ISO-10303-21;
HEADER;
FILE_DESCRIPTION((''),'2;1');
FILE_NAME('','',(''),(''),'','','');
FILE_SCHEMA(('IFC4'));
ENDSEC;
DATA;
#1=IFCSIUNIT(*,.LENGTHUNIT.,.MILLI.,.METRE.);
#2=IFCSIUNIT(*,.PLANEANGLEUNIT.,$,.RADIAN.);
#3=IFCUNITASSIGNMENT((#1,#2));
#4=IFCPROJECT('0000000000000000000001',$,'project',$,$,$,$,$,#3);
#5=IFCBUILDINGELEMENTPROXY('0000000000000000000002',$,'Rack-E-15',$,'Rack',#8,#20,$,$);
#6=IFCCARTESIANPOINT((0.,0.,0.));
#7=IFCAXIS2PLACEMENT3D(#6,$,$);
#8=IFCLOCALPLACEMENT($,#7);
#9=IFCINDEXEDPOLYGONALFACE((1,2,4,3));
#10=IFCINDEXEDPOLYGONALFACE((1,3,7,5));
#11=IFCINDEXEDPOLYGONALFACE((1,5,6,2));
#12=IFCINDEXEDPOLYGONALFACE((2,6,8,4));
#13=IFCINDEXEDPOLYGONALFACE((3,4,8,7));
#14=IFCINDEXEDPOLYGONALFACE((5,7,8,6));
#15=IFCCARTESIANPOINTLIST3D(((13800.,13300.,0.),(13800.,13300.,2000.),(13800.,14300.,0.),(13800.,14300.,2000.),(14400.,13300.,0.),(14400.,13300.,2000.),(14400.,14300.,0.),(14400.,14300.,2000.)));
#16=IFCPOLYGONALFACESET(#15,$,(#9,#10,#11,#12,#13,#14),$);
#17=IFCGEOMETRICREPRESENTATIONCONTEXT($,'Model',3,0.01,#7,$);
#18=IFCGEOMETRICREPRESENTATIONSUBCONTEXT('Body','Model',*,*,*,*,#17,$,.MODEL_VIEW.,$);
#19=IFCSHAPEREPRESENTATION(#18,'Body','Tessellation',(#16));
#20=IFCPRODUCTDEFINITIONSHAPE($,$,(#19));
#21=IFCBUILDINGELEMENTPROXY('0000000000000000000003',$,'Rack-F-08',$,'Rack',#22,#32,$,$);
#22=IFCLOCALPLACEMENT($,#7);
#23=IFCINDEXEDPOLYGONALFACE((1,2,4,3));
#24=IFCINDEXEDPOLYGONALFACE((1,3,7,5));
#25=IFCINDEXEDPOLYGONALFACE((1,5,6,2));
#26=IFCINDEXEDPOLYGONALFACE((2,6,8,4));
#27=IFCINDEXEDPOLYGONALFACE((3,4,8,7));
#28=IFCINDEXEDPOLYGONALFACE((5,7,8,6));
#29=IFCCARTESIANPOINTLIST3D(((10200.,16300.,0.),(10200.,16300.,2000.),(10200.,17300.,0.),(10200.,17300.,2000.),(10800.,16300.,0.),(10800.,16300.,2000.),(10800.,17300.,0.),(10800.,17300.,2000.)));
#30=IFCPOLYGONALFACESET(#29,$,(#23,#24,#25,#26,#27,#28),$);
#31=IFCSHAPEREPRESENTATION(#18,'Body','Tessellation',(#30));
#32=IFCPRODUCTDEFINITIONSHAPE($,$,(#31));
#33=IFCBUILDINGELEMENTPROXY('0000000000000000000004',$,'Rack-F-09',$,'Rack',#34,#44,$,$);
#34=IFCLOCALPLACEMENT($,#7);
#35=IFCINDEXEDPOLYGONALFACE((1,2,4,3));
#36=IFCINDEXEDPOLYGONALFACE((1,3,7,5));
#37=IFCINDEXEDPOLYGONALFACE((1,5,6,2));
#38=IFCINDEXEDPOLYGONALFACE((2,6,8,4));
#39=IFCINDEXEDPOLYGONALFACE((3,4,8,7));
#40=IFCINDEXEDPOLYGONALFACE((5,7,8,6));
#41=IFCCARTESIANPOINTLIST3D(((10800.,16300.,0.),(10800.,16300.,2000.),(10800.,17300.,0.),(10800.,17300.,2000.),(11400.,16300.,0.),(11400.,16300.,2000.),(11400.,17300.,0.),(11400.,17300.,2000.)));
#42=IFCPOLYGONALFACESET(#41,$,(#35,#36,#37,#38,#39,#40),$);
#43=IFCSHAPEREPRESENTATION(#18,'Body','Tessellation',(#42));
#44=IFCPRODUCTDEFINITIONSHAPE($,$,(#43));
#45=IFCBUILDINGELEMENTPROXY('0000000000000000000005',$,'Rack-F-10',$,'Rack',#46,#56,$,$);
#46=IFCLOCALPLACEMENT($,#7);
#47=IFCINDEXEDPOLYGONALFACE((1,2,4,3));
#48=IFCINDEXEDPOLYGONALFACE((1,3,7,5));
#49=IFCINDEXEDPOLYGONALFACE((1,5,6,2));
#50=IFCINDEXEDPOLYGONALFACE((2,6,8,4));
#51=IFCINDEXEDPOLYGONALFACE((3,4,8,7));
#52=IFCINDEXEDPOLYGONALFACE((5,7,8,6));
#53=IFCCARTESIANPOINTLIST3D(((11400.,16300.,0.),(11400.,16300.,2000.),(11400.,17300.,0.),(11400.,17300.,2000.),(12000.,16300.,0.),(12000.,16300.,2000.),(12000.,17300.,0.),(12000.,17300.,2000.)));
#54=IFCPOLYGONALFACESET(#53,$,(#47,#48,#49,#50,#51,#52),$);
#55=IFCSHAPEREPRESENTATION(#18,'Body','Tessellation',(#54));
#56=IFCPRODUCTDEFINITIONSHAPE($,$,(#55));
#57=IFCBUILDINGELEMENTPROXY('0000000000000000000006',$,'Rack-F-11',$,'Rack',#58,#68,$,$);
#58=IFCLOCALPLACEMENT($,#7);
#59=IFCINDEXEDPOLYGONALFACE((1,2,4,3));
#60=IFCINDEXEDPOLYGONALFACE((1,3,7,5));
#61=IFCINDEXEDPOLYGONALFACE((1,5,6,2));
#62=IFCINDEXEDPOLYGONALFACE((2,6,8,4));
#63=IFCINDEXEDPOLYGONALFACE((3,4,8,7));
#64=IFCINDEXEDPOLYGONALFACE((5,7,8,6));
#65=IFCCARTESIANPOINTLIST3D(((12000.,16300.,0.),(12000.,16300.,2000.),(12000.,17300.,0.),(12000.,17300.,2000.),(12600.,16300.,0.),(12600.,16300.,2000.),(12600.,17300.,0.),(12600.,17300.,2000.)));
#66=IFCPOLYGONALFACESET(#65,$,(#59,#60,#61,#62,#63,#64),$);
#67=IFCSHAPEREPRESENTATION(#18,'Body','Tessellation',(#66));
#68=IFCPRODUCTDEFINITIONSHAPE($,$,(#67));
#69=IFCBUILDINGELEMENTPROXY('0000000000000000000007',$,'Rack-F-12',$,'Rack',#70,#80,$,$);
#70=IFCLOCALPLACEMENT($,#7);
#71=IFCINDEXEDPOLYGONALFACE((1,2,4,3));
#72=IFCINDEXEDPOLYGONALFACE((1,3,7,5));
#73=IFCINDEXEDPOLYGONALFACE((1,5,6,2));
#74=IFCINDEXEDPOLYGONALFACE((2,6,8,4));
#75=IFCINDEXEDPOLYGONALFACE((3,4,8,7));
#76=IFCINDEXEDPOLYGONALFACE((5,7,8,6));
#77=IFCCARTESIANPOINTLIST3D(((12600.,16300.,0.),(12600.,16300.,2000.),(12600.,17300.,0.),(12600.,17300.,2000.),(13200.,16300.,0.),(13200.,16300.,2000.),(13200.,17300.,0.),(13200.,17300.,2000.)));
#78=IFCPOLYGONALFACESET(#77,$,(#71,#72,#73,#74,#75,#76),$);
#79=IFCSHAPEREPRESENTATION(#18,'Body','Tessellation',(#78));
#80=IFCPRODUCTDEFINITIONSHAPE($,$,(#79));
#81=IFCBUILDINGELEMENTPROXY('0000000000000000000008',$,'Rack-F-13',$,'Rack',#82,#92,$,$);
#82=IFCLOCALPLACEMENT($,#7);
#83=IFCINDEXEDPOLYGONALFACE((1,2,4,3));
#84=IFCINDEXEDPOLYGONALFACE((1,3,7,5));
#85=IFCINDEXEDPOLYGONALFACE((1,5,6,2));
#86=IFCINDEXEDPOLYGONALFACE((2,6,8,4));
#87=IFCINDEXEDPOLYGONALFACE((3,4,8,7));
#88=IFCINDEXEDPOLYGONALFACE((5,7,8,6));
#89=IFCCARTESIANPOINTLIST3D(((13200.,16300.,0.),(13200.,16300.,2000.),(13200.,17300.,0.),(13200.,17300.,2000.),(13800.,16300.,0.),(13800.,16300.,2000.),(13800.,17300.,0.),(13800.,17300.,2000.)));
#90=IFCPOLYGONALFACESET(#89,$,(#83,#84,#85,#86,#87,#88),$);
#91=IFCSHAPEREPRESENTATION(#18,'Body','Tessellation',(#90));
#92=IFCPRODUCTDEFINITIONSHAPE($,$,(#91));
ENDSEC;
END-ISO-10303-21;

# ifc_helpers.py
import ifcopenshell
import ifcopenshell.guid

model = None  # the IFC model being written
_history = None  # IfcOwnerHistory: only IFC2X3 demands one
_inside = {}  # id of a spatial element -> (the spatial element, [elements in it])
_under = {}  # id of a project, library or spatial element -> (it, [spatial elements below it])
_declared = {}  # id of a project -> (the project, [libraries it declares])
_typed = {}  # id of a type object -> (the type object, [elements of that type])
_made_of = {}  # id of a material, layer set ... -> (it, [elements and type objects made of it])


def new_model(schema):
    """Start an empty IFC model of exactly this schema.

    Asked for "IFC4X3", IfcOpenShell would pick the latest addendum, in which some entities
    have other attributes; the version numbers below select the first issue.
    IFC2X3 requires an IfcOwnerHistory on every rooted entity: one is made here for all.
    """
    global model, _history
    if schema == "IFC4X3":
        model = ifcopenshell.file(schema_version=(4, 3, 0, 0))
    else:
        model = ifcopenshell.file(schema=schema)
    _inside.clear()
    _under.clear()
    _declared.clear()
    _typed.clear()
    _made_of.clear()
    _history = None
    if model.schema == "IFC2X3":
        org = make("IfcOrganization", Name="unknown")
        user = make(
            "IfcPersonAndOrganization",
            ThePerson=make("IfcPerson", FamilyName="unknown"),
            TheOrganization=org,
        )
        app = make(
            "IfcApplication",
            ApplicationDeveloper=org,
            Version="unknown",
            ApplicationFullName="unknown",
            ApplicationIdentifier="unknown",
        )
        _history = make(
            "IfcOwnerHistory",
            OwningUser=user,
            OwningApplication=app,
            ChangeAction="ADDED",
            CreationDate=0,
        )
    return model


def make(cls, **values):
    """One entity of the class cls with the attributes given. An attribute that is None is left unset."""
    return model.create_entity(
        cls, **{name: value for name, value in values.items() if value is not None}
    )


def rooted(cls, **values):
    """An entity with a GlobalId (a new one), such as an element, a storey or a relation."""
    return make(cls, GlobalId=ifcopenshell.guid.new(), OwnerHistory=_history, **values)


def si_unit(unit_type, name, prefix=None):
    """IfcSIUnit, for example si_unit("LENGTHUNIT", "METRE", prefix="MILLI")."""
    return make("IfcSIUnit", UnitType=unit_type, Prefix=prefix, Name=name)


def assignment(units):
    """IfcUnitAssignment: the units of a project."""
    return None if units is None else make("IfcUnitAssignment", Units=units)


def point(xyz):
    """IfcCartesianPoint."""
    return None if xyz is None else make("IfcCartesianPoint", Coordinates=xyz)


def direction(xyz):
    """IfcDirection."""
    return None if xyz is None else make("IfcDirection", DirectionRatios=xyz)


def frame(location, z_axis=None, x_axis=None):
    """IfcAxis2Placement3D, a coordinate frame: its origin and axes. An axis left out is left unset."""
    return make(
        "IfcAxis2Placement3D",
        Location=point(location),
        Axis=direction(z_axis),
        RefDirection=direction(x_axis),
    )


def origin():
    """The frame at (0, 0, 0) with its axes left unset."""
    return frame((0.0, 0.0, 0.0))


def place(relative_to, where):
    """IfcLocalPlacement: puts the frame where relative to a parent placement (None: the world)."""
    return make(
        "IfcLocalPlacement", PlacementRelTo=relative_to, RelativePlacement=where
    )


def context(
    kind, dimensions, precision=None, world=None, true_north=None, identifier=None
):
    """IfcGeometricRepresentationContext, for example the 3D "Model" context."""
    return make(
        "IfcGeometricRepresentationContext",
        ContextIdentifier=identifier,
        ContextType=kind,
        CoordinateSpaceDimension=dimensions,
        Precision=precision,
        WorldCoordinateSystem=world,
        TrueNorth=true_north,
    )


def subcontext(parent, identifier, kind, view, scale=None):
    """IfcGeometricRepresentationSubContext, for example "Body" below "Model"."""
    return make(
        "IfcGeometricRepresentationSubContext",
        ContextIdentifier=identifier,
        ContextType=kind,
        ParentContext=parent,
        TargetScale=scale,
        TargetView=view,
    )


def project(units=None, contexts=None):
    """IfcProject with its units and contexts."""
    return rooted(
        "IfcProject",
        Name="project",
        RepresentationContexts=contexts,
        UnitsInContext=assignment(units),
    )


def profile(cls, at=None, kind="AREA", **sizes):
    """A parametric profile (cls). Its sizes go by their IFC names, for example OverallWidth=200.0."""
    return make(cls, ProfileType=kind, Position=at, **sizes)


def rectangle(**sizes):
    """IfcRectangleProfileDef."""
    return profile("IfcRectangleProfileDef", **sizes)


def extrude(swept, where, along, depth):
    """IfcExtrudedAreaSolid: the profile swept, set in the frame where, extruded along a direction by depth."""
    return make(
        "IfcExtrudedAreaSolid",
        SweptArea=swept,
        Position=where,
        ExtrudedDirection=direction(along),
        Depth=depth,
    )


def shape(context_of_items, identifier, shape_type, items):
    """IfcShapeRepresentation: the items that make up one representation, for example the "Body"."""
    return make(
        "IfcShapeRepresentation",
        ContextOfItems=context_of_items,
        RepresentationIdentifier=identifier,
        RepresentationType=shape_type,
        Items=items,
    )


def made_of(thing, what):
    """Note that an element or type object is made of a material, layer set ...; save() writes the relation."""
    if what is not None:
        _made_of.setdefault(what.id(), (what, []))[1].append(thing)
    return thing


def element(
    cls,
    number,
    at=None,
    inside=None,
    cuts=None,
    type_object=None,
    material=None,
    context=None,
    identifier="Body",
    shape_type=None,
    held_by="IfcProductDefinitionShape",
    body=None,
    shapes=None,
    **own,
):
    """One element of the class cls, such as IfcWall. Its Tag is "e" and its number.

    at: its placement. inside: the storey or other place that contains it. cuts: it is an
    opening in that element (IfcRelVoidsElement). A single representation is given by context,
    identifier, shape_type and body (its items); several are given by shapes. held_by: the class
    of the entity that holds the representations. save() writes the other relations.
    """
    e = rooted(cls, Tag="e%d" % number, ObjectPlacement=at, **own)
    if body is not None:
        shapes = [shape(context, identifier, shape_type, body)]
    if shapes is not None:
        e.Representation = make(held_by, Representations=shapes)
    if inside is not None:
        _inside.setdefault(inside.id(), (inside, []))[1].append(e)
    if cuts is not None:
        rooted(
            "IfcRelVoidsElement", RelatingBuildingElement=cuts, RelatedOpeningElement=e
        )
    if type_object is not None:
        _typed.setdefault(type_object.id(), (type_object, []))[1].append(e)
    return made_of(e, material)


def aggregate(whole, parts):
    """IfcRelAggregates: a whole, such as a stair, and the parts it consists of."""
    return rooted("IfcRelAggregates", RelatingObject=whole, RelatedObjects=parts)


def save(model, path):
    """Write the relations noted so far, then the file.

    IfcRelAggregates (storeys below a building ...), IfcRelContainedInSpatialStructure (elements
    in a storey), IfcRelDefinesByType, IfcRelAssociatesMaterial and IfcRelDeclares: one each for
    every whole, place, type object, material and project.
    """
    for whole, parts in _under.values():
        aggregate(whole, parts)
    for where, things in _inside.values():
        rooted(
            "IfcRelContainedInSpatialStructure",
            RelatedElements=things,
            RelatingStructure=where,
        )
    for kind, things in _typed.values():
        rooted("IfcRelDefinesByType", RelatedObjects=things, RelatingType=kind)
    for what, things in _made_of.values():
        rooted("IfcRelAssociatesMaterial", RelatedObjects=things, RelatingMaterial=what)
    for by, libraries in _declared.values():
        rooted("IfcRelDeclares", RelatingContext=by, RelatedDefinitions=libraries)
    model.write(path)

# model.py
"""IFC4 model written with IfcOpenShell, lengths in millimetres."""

from ifc_helpers import new_model, si_unit, frame, origin, place, context, subcontext, project, rectangle, extrude, element, save


model = new_model("IFC4")

# Units and contexts
model_context = context("Model", 3, precision=0.01, world=origin())
body_context = subcontext(model_context, "Body", "Model", "MODEL_VIEW")
ifc_project = project(units=[si_unit("LENGTHUNIT", "METRE", prefix="MILLI"), si_unit("PLANEANGLEUNIT", "RADIAN")])

# Shared definitions
placement = place(None, origin())

# Building element proxies
for number, where, name in (
    (1, (14100.0, 13800.0, 0.0), "Rack-E-15"),
    (2, (10500.0, 16800.0, 0.0), "Rack-F-08"),
    (3, (11100.0, 16800.0, 0.0), "Rack-F-09"),
    (4, (11700.0, 16800.0, 0.0), "Rack-F-10"),
    (5, (12300.0, 16800.0, 0.0), "Rack-F-11"),
    (6, (12900.0, 16800.0, 0.0), "Rack-F-12"),
    (7, (13500.0, 16800.0, 0.0), "Rack-F-13"),
):
    element("IfcBuildingElementProxy", number, at=place(placement, frame(where)), Name=name, ObjectType="Rack", context=body_context, shape_type="SweptSolid", body=[
        extrude(rectangle(XDim=600.0, YDim=1000.0), origin(), (0.0, 0.0, 1.0), 2000.0),
    ])

save(model, "model.ifc")
